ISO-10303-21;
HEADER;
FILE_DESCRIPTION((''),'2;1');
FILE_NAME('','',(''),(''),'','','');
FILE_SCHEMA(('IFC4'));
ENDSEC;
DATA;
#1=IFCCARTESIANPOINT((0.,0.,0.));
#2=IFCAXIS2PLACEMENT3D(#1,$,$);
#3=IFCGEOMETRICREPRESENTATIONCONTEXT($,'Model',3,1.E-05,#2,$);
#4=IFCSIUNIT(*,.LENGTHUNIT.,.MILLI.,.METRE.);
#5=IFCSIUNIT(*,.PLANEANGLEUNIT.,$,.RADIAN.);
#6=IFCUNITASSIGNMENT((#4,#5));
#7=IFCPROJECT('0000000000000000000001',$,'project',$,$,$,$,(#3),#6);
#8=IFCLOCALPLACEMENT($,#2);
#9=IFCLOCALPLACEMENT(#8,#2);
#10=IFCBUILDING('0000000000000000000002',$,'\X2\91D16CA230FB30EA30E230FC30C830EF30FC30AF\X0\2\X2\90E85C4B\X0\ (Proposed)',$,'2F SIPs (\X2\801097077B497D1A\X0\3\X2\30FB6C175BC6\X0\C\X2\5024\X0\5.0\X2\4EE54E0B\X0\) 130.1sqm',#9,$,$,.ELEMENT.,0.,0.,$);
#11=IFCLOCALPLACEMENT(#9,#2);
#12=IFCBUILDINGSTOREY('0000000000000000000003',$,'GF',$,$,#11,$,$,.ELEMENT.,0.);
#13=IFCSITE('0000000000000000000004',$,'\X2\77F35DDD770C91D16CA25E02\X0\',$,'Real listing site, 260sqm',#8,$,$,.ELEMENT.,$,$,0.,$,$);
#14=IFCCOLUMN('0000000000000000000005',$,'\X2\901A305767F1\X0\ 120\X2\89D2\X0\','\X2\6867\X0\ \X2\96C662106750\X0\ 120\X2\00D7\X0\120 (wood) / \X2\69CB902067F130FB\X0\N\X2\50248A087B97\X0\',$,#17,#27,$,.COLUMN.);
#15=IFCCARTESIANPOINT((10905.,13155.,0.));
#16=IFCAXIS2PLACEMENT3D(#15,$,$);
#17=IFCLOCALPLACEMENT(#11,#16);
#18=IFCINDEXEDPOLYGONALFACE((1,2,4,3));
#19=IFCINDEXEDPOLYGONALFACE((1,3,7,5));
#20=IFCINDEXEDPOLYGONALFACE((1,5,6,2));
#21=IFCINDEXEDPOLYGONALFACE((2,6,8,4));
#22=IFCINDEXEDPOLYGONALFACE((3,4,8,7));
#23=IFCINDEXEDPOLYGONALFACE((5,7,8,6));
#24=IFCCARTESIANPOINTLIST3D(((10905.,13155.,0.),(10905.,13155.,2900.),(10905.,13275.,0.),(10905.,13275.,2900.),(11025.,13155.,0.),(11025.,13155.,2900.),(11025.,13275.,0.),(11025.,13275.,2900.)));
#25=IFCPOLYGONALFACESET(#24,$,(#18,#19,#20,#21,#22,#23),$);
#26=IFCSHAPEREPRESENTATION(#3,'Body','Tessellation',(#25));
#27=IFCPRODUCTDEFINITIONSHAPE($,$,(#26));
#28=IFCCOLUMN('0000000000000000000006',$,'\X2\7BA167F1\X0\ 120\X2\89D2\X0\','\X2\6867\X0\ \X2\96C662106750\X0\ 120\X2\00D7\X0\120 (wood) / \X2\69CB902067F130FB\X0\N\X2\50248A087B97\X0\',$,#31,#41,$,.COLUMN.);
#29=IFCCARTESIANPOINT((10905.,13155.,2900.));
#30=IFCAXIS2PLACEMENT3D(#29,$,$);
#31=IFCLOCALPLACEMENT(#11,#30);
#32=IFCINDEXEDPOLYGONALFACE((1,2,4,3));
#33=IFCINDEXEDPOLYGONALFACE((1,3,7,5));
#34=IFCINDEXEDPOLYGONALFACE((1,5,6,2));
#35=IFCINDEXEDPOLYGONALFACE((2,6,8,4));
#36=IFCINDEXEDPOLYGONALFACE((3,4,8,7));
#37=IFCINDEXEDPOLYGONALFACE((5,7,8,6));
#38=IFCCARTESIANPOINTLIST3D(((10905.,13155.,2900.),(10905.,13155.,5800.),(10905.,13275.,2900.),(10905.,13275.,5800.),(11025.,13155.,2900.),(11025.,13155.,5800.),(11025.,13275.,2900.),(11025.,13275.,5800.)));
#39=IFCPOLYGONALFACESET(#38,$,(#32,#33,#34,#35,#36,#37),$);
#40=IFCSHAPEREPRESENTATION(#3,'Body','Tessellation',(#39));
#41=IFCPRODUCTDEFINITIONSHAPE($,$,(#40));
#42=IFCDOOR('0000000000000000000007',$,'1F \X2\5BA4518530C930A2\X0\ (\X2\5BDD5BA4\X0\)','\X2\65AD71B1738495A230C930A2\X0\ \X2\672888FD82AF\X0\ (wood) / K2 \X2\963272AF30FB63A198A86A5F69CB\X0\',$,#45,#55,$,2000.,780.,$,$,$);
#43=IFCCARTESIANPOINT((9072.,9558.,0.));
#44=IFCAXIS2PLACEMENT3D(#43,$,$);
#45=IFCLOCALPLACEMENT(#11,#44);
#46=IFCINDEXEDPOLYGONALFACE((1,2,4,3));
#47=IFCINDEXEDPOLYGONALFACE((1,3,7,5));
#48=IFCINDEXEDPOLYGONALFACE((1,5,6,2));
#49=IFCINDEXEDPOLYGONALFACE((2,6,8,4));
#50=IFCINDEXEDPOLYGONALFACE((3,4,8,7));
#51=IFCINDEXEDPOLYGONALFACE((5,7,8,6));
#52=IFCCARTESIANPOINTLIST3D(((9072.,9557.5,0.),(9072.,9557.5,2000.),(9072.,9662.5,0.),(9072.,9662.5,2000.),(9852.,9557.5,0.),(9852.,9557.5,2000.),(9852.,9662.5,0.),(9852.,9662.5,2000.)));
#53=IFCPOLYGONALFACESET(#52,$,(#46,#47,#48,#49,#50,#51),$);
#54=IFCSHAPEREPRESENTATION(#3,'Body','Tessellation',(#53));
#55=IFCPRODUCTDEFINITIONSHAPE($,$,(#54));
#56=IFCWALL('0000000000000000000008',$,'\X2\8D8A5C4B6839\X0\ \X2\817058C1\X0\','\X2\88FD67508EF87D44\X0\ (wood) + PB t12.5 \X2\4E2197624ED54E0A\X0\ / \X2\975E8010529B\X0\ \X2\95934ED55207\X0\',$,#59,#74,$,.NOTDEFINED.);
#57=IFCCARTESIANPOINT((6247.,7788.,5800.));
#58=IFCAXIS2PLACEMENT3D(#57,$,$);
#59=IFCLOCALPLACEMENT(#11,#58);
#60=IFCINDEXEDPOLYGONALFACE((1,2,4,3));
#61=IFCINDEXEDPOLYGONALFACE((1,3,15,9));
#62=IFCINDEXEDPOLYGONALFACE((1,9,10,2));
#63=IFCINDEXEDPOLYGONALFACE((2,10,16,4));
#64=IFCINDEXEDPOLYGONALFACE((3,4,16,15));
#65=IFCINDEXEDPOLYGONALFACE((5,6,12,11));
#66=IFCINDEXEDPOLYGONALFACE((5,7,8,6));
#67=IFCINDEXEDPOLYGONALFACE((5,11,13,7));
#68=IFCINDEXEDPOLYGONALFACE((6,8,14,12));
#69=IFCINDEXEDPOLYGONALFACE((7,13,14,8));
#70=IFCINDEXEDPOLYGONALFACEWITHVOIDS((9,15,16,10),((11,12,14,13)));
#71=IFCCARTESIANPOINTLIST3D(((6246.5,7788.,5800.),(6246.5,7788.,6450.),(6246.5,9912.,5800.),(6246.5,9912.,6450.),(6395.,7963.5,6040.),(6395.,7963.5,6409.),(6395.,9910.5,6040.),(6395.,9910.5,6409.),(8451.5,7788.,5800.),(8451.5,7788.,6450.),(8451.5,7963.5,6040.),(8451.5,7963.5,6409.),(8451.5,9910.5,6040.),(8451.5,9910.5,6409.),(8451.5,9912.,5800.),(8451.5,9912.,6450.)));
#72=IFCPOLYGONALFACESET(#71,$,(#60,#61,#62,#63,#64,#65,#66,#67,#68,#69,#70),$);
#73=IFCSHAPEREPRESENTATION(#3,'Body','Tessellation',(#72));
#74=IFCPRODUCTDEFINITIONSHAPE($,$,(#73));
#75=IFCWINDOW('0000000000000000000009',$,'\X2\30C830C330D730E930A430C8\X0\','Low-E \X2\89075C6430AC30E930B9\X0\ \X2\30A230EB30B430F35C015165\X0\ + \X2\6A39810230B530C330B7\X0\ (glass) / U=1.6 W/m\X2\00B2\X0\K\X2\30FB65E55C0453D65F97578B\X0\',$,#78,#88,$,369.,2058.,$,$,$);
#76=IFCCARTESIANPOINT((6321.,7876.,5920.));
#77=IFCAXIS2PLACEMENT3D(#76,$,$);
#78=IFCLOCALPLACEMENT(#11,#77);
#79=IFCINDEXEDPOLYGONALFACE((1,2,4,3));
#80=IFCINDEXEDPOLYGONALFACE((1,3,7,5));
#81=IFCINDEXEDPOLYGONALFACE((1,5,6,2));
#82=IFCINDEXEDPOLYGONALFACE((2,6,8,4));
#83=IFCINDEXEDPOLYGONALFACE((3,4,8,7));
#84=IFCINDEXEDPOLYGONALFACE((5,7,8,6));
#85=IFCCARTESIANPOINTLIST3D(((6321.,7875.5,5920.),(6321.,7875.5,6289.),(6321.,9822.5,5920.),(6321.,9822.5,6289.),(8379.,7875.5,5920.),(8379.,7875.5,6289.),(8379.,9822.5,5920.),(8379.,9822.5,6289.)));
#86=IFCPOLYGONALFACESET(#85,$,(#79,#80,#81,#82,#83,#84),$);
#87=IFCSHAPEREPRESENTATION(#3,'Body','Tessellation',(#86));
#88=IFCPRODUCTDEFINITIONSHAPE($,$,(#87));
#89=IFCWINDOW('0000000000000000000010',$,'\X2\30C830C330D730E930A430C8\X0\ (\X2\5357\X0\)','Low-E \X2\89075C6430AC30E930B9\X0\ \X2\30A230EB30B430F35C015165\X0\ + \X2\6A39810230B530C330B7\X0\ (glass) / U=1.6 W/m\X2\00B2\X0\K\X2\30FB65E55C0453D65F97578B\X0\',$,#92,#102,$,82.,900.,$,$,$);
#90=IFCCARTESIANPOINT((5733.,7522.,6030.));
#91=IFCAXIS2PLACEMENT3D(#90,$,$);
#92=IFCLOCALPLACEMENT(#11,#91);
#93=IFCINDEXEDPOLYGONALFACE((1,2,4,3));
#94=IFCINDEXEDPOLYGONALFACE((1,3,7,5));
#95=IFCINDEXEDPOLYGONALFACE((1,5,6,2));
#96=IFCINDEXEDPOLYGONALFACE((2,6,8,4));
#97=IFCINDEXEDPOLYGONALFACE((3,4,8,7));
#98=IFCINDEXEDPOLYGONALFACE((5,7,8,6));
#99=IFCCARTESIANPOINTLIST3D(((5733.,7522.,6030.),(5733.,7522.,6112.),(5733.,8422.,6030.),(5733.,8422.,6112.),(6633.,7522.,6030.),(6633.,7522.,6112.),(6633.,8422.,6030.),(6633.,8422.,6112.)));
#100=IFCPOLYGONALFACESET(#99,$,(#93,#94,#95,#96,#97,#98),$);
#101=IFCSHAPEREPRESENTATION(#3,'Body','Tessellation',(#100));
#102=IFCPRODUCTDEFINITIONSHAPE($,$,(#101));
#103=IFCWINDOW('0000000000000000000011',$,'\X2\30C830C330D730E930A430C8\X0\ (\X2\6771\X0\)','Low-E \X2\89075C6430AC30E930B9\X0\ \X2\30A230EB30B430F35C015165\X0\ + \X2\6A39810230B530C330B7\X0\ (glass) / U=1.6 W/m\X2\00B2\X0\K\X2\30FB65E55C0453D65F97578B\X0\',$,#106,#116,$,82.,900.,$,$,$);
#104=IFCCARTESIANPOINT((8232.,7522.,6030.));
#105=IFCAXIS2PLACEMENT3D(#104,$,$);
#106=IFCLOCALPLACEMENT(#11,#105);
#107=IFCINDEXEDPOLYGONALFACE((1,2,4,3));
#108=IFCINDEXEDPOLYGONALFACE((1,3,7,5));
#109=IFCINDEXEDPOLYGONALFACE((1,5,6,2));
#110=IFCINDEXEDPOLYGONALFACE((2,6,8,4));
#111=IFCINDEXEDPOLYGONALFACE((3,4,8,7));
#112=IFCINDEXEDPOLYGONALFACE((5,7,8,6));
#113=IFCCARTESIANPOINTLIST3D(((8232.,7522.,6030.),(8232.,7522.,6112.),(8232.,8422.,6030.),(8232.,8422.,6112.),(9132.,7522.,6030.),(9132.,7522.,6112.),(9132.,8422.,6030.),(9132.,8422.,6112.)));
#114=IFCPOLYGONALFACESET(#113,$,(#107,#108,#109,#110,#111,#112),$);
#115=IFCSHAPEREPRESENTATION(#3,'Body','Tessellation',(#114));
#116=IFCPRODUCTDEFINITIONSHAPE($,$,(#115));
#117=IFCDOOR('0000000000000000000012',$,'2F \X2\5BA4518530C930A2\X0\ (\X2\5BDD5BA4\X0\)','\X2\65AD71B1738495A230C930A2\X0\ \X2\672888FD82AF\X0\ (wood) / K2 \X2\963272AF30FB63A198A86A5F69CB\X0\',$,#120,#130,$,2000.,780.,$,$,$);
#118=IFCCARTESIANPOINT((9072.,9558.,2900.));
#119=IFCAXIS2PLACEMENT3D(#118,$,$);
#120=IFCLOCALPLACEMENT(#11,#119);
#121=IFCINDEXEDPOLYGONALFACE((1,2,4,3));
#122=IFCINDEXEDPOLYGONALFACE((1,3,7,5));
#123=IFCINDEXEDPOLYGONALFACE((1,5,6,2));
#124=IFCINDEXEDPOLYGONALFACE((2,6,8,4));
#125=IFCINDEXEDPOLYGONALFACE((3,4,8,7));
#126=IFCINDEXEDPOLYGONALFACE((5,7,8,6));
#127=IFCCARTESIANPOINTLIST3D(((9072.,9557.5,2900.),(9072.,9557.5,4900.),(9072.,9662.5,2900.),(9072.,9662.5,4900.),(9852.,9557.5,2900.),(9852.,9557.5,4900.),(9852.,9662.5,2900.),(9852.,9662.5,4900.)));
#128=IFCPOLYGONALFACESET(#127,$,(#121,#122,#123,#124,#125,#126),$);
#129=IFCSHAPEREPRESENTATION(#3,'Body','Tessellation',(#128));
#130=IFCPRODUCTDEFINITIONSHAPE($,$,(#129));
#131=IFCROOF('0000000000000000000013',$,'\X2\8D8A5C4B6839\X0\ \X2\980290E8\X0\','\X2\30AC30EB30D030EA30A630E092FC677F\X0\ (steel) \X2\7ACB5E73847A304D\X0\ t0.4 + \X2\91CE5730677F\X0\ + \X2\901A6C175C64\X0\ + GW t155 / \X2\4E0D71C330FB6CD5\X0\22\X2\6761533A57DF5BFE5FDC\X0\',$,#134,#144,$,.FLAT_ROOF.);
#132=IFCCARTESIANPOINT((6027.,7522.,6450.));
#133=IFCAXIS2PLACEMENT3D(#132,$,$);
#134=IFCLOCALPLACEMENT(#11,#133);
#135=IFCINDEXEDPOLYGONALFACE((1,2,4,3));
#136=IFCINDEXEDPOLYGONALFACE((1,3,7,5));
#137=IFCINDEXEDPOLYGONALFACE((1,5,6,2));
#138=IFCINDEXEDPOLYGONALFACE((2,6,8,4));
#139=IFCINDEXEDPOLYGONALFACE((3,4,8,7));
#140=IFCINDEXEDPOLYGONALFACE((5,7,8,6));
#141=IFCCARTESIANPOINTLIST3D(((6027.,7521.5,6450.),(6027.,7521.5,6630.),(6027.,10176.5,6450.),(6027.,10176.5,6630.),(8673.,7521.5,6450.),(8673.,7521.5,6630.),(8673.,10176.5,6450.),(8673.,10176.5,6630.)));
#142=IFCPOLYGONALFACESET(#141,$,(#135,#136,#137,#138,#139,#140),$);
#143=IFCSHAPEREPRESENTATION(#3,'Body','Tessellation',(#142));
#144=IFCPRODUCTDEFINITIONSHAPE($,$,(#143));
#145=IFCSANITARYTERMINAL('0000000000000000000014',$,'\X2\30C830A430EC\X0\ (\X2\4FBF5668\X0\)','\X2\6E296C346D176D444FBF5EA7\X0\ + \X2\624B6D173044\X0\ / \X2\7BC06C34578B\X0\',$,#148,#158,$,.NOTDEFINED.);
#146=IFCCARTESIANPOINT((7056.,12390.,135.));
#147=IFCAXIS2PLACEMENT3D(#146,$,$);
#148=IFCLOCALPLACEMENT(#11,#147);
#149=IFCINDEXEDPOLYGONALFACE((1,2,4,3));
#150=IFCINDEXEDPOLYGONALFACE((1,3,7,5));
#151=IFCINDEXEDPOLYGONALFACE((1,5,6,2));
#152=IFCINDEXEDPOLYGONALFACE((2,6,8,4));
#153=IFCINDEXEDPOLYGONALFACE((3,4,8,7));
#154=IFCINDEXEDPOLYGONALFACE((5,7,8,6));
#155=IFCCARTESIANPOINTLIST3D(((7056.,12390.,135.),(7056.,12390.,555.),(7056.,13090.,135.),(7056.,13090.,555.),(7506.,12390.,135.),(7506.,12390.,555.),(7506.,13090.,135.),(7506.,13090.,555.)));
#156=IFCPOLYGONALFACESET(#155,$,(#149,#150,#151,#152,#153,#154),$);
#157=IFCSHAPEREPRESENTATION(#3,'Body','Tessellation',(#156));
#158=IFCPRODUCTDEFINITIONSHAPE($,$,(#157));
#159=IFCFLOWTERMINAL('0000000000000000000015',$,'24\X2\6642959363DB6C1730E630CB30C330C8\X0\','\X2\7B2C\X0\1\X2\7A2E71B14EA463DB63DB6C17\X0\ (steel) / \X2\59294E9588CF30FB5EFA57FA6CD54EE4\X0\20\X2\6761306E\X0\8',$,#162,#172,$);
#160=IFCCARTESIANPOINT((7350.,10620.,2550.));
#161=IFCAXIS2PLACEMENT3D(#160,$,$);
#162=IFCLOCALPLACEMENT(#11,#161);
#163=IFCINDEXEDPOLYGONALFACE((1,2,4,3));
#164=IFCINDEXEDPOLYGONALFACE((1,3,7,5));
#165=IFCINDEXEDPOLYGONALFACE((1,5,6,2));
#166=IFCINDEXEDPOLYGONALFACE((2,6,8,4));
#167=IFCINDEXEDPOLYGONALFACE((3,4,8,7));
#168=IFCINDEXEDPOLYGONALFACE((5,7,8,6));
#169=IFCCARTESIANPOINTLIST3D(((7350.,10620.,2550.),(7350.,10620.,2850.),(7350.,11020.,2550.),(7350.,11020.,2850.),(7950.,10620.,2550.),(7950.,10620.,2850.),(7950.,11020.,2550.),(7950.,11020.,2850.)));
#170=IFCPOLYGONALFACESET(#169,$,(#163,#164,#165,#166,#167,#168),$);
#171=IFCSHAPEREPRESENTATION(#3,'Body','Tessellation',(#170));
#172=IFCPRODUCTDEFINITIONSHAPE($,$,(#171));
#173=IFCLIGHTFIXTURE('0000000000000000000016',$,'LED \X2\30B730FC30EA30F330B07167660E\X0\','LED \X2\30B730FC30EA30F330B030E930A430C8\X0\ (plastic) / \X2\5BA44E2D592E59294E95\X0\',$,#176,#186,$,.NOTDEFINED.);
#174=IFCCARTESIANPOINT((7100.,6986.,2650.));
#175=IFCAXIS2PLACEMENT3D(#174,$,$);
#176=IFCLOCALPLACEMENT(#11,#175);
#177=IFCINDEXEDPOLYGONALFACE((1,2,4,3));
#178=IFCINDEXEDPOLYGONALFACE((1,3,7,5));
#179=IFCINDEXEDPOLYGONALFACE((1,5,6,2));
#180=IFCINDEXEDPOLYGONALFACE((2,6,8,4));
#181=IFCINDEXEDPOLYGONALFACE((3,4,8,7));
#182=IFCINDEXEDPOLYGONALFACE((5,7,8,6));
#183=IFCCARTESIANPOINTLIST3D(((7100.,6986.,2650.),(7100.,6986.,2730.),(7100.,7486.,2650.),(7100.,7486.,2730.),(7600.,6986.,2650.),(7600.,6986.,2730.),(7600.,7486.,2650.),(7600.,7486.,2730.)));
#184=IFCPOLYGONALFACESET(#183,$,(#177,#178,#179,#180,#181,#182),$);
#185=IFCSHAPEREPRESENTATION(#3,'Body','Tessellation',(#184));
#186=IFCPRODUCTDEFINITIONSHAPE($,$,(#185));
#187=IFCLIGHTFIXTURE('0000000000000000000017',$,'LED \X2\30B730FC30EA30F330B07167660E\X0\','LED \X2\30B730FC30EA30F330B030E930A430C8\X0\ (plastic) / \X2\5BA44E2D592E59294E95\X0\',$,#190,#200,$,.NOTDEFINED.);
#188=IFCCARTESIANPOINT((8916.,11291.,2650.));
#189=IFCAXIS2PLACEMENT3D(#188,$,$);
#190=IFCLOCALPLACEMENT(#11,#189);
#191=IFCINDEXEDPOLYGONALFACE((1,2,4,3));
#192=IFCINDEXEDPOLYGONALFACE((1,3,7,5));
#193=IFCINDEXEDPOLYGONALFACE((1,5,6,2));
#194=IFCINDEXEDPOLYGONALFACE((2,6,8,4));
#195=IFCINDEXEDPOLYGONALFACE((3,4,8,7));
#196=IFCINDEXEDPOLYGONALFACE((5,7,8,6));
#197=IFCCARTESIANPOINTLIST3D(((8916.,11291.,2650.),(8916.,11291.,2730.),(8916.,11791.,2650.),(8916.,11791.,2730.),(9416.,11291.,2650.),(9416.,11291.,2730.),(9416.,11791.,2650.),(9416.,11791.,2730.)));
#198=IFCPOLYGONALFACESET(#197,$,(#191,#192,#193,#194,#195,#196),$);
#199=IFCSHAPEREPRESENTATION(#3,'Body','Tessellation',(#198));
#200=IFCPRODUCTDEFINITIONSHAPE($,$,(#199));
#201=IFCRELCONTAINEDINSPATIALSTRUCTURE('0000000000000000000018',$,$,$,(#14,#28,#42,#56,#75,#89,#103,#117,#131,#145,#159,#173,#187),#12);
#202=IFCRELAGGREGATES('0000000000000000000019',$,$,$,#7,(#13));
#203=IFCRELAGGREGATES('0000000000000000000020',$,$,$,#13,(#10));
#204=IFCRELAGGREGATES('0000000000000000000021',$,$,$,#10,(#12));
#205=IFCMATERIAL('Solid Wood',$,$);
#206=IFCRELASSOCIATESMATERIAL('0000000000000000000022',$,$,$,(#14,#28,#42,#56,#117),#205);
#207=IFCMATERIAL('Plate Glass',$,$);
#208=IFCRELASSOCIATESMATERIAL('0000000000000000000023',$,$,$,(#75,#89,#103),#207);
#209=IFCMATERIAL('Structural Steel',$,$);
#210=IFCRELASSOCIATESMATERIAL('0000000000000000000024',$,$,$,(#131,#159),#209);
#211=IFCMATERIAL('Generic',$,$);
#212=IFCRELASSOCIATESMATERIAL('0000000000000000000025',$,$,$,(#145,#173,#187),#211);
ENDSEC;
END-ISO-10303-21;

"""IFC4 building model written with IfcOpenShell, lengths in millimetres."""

from ifc_helpers import new_model, si_unit, frame, frame_2d, origin, place, context, project, spatial, rectangle, extrude, material, element, fill, save


model = new_model("IFC4")

# Units and contexts
model_context = context("Model", 3, precision=1e-05, world=origin())
ifc_project = project(units=[si_unit("LENGTHUNIT", "METRE", prefix="MILLI"), si_unit("PLANEANGLEUNIT", "RADIAN")], contexts=[model_context])

# Site, building, storey
site_placement = place(None, origin())
site = spatial("IfcSite", under=ifc_project, at=site_placement, Name="石川県金沢市", ObjectType="Real listing site, 260sqm", CompositionType="ELEMENT", RefElevation=0.0)
building_placement = place(site_placement, origin())
building = spatial("IfcBuilding", under=site, at=building_placement, Name="金沢・リモートワーク2部屋 (Proposed)", ObjectType="2F SIPs (耐震等級3・気密C値5.0以下) 130.1sqm", CompositionType="ELEMENT", ElevationOfRefHeight=0.0, ElevationOfTerrain=0.0)
storey_placement = place(building_placement, origin())
storey = spatial("IfcBuildingStorey", under=building, at=storey_placement, Name="GF", CompositionType="ELEMENT", Elevation=0.0)

# Columns
ifc_material_1 = material(Name="Solid Wood")
column_1_placement = place(storey_placement, frame((10905.0, 13155.0, 0.0)))
element("IfcColumn", 1, at=column_1_placement, inside=storey, material=ifc_material_1, Name="通し柱 120角", Description="桧 集成材 120×120 (wood) / 構造柱・N値計算", PredefinedType="COLUMN", context=model_context, shape_type="SweptSolid", body=[
    extrude(rectangle(XDim=120.0, YDim=120.0, at=frame_2d((60.0, 60.0))), frame((10905.0, 13155.0, 0.0)), (0.0, 0.0, 1.0), 2900.0),
])
column_2_placement = place(storey_placement, frame((10905.0, 13155.0, 2900.0)))
element("IfcColumn", 2, at=column_2_placement, inside=storey, material=ifc_material_1, Name="管柱 120角", Description="桧 集成材 120×120 (wood) / 構造柱・N値計算", PredefinedType="COLUMN", context=model_context, shape_type="SweptSolid", body=[
    extrude(rectangle(XDim=120.0, YDim=120.0, at=frame_2d((60.0, 60.0))), frame((10905.0, 13155.0, 2900.0)), (0.0, 0.0, 1.0), 2900.0),
])

# Door
door_1_placement = place(storey_placement, frame((9072.0, 9558.0, 0.0)))
element("IfcDoor", 3, at=door_1_placement, inside=storey, material=ifc_material_1, Name="1F 室内ドア (寝室)", Description="断熱玄関ドア 木製芯 (wood) / K2 防犯・採風機構", OverallHeight=2000.0, OverallWidth=780.0, context=model_context, shape_type="SweptSolid", body=[
    extrude(rectangle(XDim=780.0, YDim=105.0, at=frame_2d((390.0, 52.0))), frame((9072.0, 9558.0, 0.0)), (0.0, 0.0, 1.0), 2000.0),
])

# Wall, openings, windows
wall_1_placement = place(storey_placement, frame((6247.0, 7788.0, 5800.0)))
wall_1 = element("IfcWall", 4, at=wall_1_placement, inside=storey, material=ifc_material_1, Name="越屋根 腰壁", Description="製材軸組 (wood) + PB t12.5 両面仕上 / 非耐力 間仕切", PredefinedType="NOTDEFINED", context=model_context, shape_type="SweptSolid", body=[
    extrude(rectangle(XDim=2205.0, YDim=2124.0, at=frame_2d((1102.0, 1062.0))), frame((6247.0, 7788.0, 5800.0)), (0.0, 0.0, 1.0), 650.0),
])
opening_1_placement = place(storey_placement, frame((6321.0, 7876.0, 5920.0)))
opening_1 = element("IfcOpeningElement", 5, at=opening_1_placement, cuts=wall_1, PredefinedType="NOTDEFINED", context=model_context, shape_type="SweptSolid", body=[
    extrude(rectangle(XDim=2058.0, YDim=1947.0, at=frame_2d((1029.0, 973.0))), frame((6321.0, 7876.0, 5920.0)), (0.0, 0.0, 1.0), 369.0),
])
opening_2_placement = place(storey_placement, frame((5733.0, 7522.0, 6030.0)))
opening_2 = element("IfcOpeningElement", 6, at=opening_2_placement, cuts=wall_1, PredefinedType="NOTDEFINED", context=model_context, shape_type="SweptSolid", body=[
    extrude(rectangle(XDim=900.0, YDim=900.0, at=frame_2d((450.0, 450.0))), frame((5733.0, 7522.0, 6030.0)), (0.0, 0.0, 1.0), 82.0),
])
opening_3_placement = place(storey_placement, frame((8232.0, 7522.0, 6030.0)))
opening_3 = element("IfcOpeningElement", 7, at=opening_3_placement, cuts=wall_1, PredefinedType="NOTDEFINED", context=model_context, shape_type="SweptSolid", body=[
    extrude(rectangle(XDim=900.0, YDim=900.0, at=frame_2d((450.0, 450.0))), frame((8232.0, 7522.0, 6030.0)), (0.0, 0.0, 1.0), 82.0),
])
ifc_material_2 = material(Name="Plate Glass")
window_1_placement = place(storey_placement, frame((6321.0, 7876.0, 5920.0)))
window_1 = element("IfcWindow", 8, at=window_1_placement, inside=storey, material=ifc_material_2, Name="トップライト", Description="Low-E 複層ガラス アルゴン封入 + 樹脂サッシ (glass) / U=1.6 W/m²K・日射取得型", OverallHeight=369.0, OverallWidth=2058.0, context=model_context, shape_type="SweptSolid", body=[
    extrude(rectangle(XDim=2058.0, YDim=1947.0, at=frame_2d((1029.0, 973.0))), frame((6321.0, 7876.0, 5920.0)), (0.0, 0.0, 1.0), 369.0),
])
fill(opening_1, window_1)
window_2_placement = place(storey_placement, frame((5733.0, 7522.0, 6030.0)))
window_2 = element("IfcWindow", 9, at=window_2_placement, inside=storey, material=ifc_material_2, Name="トップライト (南)", Description="Low-E 複層ガラス アルゴン封入 + 樹脂サッシ (glass) / U=1.6 W/m²K・日射取得型", OverallHeight=82.0, OverallWidth=900.0, context=model_context, shape_type="SweptSolid", body=[
    extrude(rectangle(XDim=900.0, YDim=900.0, at=frame_2d((450.0, 450.0))), frame((5733.0, 7522.0, 6030.0)), (0.0, 0.0, 1.0), 82.0),
])
fill(opening_2, window_2)
window_3_placement = place(storey_placement, frame((8232.0, 7522.0, 6030.0)))
window_3 = element("IfcWindow", 10, at=window_3_placement, inside=storey, material=ifc_material_2, Name="トップライト (東)", Description="Low-E 複層ガラス アルゴン封入 + 樹脂サッシ (glass) / U=1.6 W/m²K・日射取得型", OverallHeight=82.0, OverallWidth=900.0, context=model_context, shape_type="SweptSolid", body=[
    extrude(rectangle(XDim=900.0, YDim=900.0, at=frame_2d((450.0, 450.0))), frame((8232.0, 7522.0, 6030.0)), (0.0, 0.0, 1.0), 82.0),
])
fill(opening_3, window_3)

# Door
door_2_placement = place(storey_placement, frame((9072.0, 9558.0, 2900.0)))
element("IfcDoor", 11, at=door_2_placement, inside=storey, material=ifc_material_1, Name="2F 室内ドア (寝室)", Description="断熱玄関ドア 木製芯 (wood) / K2 防犯・採風機構", OverallHeight=2000.0, OverallWidth=780.0, context=model_context, shape_type="SweptSolid", body=[
    extrude(rectangle(XDim=780.0, YDim=105.0, at=frame_2d((390.0, 52.0))), frame((9072.0, 9558.0, 2900.0)), (0.0, 0.0, 1.0), 2000.0),
])

# Roof
ifc_material_3 = material(Name="Structural Steel")
roof_placement = place(storey_placement, frame((6027.0, 7522.0, 6450.0)))
element("IfcRoof", 12, at=roof_placement, inside=storey, material=ifc_material_3, Name="越屋根 頂部", Description="ガルバリウム鋼板 (steel) 立平葺き t0.4 + 野地板 + 通気層 + GW t155 / 不燃・法22条区域対応", PredefinedType="FLAT_ROOF", context=model_context, shape_type="SweptSolid", body=[
    extrude(rectangle(XDim=2646.0, YDim=2655.0, at=frame_2d((1323.0, 1327.0))), frame((6027.0, 7522.0, 6450.0)), (0.0, 0.0, 1.0), 180.0),
])

# Sanitary terminal
ifc_material_4 = material(Name="Generic")
sanitary_terminal_placement = place(storey_placement, frame((7056.0, 12390.0, 135.0)))
element("IfcSanitaryTerminal", 13, at=sanitary_terminal_placement, inside=storey, material=ifc_material_4, Name="トイレ (便器)", Description="温水洗浄便座 + 手洗い / 節水型", PredefinedType="NOTDEFINED", context=model_context, shape_type="SweptSolid", body=[
    extrude(rectangle(XDim=450.0, YDim=700.0, at=frame_2d((225.0, 350.0))), frame((7056.0, 12390.0, 135.0)), (0.0, 0.0, 1.0), 420.0),
])

# Flow terminal
flow_terminal_placement = place(storey_placement, frame((7350.0, 10620.0, 2550.0)))
element("IfcFlowTerminal", 14, at=flow_terminal_placement, inside=storey, material=ifc_material_3, Name="24時間換気ユニット", Description="第1種熱交換換気 (steel) / 天井裏・建基法令20条の8", context=model_context, shape_type="SweptSolid", body=[
    extrude(rectangle(XDim=600.0, YDim=400.0, at=frame_2d((300.0, 200.0))), frame((7350.0, 10620.0, 2550.0)), (0.0, 0.0, 1.0), 300.0),
])

# Light fixtures
light_fixture_1_placement = place(storey_placement, frame((7100.0, 6986.0, 2650.0)))
element("IfcLightFixture", 15, at=light_fixture_1_placement, inside=storey, material=ifc_material_4, Name="LED シーリング照明", Description="LED シーリングライト (plastic) / 室中央天井", PredefinedType="NOTDEFINED", context=model_context, shape_type="SweptSolid", body=[
    extrude(rectangle(XDim=500.0, YDim=500.0, at=frame_2d((250.0, 250.0))), frame((7100.0, 6986.0, 2650.0)), (0.0, 0.0, 1.0), 80.0),
])
light_fixture_2_placement = place(storey_placement, frame((8916.0, 11291.0, 2650.0)))
element("IfcLightFixture", 16, at=light_fixture_2_placement, inside=storey, material=ifc_material_4, Name="LED シーリング照明", Description="LED シーリングライト (plastic) / 室中央天井", PredefinedType="NOTDEFINED", context=model_context, shape_type="SweptSolid", body=[
    extrude(rectangle(XDim=500.0, YDim=500.0, at=frame_2d((250.0, 250.0))), frame((8916.0, 11291.0, 2650.0)), (0.0, 0.0, 1.0), 80.0),
])

save(model, "model.ifc")
